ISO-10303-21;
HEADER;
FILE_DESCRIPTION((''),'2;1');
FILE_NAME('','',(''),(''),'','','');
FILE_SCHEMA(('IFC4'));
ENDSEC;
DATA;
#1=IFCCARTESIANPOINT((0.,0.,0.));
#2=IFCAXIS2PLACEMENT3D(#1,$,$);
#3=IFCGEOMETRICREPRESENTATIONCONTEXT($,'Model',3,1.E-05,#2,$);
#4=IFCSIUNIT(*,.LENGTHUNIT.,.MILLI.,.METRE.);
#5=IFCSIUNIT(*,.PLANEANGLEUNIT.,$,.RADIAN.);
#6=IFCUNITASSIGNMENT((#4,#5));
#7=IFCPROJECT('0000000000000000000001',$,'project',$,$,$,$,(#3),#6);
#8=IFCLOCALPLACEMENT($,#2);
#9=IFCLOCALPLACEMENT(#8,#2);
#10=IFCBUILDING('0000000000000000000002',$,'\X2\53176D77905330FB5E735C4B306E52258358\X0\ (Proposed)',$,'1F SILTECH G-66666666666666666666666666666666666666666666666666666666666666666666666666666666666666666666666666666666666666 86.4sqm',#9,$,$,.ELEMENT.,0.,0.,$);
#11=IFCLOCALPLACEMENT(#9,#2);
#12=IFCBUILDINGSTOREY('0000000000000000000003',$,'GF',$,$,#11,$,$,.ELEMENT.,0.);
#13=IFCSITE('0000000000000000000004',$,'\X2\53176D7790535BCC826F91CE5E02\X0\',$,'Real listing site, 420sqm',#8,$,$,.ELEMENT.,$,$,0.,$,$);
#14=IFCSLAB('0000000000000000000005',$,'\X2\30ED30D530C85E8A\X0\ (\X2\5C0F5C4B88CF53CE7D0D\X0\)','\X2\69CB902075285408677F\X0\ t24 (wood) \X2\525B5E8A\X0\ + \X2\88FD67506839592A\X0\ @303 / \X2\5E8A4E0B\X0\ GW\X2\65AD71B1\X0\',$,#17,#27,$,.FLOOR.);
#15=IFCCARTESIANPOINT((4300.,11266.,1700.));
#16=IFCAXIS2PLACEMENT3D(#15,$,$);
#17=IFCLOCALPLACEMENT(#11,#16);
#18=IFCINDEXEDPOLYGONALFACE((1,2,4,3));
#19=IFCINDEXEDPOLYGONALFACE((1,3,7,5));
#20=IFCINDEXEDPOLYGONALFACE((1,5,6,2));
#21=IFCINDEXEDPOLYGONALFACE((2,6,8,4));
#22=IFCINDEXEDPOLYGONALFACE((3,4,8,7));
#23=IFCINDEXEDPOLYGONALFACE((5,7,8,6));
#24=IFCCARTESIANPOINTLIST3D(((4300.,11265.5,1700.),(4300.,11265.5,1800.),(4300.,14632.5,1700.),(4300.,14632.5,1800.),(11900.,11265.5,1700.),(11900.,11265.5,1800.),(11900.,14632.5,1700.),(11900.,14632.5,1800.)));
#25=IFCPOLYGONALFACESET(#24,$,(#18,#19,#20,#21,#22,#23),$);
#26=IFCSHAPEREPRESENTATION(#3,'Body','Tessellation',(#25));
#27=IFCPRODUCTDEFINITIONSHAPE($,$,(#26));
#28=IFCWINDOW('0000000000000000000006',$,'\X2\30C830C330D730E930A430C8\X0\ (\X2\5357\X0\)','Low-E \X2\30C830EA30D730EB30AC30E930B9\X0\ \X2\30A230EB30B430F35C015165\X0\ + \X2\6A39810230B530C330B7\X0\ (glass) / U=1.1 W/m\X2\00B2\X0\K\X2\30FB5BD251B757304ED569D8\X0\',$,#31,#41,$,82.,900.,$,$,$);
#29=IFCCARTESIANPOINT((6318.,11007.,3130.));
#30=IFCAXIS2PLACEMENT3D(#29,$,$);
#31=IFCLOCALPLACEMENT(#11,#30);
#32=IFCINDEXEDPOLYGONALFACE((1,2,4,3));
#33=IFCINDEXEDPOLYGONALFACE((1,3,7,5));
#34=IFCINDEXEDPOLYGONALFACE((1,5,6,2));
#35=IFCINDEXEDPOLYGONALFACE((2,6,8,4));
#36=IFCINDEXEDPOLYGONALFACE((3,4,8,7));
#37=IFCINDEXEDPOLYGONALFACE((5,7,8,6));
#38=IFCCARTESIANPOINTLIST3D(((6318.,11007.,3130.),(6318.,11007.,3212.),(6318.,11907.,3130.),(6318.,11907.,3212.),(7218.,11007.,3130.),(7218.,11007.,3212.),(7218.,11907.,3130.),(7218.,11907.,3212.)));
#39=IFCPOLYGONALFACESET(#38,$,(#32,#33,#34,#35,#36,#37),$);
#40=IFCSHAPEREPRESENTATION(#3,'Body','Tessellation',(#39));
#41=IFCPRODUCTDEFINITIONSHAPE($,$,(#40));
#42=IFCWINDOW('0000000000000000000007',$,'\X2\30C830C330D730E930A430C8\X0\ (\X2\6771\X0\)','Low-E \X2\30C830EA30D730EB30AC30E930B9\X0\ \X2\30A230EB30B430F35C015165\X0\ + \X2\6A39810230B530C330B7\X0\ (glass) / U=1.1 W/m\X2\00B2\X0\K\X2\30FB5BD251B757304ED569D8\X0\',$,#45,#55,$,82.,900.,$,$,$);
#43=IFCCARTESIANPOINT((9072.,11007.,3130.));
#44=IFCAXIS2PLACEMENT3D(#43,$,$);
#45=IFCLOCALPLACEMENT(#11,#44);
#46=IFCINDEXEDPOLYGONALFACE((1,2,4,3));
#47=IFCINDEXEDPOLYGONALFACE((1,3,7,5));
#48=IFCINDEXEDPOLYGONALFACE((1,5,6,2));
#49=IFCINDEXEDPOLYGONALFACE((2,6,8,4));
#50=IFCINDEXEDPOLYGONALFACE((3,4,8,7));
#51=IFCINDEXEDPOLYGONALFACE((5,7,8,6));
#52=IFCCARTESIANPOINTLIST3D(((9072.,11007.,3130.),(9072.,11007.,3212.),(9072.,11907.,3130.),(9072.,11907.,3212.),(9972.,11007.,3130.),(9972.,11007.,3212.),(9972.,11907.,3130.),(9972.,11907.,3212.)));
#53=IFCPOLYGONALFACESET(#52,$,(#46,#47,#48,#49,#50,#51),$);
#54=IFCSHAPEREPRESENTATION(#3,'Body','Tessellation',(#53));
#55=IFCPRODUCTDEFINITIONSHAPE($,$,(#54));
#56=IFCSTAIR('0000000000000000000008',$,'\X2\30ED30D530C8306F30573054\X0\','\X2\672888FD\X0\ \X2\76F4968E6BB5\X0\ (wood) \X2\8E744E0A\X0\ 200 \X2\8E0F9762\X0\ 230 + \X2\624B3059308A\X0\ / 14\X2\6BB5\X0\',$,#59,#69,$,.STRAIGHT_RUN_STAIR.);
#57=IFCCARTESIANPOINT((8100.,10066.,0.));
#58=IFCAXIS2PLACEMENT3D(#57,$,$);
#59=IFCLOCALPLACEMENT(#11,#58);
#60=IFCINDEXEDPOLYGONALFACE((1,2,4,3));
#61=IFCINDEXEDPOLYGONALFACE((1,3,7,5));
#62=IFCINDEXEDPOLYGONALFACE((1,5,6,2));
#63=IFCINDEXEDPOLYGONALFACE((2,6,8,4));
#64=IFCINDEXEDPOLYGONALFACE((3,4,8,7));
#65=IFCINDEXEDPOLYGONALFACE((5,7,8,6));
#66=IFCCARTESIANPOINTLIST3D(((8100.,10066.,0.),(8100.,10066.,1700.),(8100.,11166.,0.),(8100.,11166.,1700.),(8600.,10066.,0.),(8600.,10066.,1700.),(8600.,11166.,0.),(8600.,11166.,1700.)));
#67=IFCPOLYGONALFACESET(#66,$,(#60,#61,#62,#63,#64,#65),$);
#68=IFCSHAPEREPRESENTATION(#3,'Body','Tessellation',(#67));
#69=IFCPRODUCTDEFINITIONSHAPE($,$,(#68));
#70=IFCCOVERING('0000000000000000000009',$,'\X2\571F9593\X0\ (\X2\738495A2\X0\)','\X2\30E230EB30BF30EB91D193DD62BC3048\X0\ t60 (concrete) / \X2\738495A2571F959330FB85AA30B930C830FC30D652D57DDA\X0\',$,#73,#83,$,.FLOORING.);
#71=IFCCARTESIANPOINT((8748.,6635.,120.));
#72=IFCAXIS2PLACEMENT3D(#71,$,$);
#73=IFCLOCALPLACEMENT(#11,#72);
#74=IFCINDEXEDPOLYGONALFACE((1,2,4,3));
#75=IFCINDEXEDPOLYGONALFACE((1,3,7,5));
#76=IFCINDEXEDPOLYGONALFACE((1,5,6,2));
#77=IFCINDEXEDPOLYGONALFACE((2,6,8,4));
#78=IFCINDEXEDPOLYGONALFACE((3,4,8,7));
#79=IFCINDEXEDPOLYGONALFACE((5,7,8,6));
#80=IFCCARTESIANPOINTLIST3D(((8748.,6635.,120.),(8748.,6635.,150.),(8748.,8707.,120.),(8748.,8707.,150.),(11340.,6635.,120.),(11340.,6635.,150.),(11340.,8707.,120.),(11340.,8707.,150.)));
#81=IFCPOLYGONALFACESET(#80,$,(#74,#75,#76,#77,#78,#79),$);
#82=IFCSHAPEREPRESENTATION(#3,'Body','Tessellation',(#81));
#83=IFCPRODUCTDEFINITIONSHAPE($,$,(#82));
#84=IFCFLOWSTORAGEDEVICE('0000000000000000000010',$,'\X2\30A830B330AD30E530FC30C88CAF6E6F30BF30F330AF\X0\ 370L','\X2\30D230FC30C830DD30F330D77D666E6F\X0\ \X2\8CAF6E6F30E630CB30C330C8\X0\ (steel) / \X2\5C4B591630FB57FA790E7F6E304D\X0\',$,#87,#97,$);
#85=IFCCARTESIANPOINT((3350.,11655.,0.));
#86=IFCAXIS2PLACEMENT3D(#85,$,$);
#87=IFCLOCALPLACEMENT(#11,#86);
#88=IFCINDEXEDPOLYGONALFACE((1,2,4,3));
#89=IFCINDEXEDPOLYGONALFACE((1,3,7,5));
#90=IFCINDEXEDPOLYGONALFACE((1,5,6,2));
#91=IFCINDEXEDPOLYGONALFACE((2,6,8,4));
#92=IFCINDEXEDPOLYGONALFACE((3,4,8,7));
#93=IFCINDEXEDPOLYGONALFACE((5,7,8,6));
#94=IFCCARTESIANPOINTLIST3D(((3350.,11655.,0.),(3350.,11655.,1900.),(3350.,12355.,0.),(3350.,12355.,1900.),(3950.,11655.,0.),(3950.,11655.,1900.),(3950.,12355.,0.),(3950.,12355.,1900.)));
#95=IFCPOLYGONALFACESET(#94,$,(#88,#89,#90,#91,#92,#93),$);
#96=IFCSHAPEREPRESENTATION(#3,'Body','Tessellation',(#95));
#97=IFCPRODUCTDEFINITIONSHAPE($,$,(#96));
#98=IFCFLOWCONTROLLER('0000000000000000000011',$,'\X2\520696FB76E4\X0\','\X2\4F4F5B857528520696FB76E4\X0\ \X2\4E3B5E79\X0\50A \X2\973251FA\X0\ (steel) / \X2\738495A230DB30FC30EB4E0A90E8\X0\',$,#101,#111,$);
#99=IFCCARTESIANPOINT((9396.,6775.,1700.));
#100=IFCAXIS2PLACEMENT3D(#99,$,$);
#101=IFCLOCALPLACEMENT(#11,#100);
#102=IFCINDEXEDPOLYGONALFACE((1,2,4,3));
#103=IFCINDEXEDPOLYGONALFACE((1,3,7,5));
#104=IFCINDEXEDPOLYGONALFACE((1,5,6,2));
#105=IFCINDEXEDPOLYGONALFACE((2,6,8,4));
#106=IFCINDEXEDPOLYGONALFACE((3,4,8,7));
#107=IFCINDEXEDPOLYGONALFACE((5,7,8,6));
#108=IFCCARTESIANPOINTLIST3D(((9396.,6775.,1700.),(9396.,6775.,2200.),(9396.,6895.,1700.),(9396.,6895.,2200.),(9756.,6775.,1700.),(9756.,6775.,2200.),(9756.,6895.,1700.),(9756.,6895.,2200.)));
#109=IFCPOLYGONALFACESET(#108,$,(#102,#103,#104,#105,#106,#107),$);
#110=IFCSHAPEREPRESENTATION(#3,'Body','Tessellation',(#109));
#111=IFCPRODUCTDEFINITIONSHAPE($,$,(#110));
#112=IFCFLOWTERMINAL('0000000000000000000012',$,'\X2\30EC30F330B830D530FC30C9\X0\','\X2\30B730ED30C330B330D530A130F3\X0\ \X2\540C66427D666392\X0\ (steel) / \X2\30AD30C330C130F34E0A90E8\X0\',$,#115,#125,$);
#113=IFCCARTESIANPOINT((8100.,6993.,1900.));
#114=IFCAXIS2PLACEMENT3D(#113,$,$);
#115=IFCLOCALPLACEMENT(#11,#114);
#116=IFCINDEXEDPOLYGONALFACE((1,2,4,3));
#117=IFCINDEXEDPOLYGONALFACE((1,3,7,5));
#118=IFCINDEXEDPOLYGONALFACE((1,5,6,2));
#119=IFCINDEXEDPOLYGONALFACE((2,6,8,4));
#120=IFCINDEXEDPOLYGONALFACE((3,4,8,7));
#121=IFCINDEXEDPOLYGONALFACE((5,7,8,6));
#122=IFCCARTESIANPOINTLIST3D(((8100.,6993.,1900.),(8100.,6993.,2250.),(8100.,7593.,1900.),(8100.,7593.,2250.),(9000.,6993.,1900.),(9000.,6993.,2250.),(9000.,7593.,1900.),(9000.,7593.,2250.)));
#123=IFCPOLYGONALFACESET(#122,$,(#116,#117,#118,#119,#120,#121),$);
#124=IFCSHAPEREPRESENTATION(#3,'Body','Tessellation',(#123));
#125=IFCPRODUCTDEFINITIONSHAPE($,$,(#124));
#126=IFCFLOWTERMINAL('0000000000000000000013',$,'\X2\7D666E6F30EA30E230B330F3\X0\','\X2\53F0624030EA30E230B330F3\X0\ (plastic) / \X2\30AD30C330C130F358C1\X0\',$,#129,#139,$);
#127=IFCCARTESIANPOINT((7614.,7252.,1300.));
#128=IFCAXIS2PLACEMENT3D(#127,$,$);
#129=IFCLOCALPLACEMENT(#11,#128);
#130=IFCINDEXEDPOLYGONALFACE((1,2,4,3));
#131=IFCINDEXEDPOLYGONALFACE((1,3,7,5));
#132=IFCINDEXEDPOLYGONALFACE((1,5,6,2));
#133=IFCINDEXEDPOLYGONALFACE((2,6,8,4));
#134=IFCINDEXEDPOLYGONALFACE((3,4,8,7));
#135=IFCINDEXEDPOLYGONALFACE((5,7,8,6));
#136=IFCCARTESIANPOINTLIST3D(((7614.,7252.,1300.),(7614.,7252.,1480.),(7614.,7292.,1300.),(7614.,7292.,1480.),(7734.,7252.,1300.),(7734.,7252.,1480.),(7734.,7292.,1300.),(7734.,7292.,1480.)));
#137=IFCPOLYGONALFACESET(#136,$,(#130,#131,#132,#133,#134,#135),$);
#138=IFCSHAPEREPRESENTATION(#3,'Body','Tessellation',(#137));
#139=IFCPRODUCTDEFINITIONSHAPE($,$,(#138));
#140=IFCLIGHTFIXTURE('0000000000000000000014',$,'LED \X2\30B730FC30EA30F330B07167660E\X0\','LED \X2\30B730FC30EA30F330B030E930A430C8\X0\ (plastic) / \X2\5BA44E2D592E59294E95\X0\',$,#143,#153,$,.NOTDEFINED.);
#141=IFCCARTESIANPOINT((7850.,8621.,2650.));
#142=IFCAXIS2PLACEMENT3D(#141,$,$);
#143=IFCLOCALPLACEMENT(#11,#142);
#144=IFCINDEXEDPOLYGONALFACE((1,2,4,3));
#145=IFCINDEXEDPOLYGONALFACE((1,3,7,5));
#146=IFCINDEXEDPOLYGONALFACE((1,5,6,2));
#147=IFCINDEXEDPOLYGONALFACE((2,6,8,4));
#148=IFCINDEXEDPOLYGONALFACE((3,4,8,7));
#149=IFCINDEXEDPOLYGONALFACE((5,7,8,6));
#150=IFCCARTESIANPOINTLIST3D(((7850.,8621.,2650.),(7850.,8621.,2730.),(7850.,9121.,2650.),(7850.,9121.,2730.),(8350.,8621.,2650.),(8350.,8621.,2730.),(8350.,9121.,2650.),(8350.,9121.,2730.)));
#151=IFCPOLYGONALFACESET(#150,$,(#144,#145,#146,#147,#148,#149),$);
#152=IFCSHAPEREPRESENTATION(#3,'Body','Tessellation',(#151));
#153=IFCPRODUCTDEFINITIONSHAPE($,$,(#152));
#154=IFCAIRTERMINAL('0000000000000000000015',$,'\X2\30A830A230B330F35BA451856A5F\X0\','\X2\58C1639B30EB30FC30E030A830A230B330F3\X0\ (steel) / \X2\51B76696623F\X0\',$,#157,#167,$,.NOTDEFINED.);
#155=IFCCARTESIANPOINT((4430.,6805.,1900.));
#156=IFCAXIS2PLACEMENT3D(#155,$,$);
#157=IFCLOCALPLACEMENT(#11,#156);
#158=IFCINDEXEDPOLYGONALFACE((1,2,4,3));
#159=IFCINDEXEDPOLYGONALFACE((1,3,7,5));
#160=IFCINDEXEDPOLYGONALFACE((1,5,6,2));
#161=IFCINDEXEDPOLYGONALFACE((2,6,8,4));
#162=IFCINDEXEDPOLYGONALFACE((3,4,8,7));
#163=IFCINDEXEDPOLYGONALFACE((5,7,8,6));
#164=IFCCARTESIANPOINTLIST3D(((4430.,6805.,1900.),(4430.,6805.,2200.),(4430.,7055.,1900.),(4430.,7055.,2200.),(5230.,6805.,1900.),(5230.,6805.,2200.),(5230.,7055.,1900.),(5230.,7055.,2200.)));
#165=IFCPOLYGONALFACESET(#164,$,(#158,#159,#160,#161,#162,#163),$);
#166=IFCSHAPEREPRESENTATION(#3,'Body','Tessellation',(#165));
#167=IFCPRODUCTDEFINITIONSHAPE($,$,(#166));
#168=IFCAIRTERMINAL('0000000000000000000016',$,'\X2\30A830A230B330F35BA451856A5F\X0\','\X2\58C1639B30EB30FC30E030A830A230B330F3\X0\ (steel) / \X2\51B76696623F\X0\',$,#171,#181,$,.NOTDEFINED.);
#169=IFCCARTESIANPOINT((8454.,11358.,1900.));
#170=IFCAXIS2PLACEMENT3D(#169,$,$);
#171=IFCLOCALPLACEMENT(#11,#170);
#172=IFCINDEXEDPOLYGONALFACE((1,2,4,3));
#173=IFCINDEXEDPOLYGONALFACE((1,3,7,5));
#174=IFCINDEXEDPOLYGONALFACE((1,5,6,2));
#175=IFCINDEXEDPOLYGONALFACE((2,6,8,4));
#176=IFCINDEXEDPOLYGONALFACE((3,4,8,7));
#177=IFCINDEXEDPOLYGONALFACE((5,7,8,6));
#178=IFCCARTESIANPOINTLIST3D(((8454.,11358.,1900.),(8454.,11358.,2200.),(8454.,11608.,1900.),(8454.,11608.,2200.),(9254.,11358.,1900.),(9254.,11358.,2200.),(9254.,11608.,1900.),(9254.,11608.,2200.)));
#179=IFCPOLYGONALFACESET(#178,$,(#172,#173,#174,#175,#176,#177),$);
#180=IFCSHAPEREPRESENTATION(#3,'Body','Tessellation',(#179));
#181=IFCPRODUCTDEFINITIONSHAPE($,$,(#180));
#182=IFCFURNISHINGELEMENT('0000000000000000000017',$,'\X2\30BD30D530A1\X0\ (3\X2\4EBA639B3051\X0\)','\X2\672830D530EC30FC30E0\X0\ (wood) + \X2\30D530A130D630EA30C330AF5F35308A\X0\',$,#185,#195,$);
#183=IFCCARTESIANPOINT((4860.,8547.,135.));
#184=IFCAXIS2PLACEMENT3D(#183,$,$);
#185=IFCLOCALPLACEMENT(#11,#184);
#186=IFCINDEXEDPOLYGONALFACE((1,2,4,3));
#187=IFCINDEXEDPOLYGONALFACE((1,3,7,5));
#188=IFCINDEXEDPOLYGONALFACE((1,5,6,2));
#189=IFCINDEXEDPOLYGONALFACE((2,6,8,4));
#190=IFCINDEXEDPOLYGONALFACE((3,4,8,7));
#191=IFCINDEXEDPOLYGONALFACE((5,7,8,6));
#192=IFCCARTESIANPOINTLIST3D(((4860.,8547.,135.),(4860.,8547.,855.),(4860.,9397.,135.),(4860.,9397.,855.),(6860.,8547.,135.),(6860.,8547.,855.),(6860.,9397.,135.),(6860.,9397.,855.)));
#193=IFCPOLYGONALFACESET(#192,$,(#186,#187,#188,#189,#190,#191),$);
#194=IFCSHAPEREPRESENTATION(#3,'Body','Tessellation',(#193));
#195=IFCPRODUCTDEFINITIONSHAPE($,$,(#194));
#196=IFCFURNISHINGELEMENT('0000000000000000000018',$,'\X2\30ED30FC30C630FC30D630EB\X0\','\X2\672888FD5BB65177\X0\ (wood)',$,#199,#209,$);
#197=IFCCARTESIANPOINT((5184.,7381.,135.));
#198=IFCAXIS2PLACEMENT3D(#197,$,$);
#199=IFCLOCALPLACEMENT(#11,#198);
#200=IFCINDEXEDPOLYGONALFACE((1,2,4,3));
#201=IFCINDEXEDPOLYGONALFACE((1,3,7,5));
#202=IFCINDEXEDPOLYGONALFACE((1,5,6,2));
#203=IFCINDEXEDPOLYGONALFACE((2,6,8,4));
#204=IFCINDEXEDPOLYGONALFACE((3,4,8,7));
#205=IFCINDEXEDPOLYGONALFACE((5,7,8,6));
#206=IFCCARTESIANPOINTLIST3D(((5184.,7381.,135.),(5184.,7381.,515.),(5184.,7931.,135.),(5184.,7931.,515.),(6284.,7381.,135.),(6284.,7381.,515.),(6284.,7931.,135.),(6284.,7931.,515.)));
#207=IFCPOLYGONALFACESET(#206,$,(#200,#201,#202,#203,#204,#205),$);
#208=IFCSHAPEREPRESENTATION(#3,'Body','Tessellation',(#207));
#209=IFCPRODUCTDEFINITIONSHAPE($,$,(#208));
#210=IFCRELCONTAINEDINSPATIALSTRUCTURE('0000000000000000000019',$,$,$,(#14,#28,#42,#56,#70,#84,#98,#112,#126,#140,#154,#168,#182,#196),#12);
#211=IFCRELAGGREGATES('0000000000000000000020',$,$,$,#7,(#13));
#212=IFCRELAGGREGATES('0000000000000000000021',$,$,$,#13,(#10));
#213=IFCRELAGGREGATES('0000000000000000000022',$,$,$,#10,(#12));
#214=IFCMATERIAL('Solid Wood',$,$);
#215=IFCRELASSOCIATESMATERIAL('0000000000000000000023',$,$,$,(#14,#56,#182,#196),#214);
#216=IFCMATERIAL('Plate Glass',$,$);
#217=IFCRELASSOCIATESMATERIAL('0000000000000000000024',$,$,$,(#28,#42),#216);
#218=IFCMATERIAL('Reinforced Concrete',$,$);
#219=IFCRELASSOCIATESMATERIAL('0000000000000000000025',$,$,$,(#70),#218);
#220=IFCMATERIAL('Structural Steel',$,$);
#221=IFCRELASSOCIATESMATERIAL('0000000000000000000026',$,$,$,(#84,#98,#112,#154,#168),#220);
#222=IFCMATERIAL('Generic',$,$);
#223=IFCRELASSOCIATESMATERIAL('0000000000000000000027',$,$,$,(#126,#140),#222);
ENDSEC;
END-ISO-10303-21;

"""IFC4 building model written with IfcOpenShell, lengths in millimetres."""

from ifc_helpers import new_model, si_unit, frame, frame_2d, origin, place, context, project, spatial, rectangle, extrude, material, element, save


model = new_model("IFC4")

# Units and contexts
model_context = context("Model", 3, precision=1e-05, world=origin())
ifc_project = project(units=[si_unit("LENGTHUNIT", "METRE", prefix="MILLI"), si_unit("PLANEANGLEUNIT", "RADIAN")], contexts=[model_context])

# Site, building, storey
site_placement = place(None, origin())
site = spatial("IfcSite", under=ifc_project, at=site_placement, Name="北海道富良野市", ObjectType="Real listing site, 420sqm", CompositionType="ELEMENT", RefElevation=0.0)
building_placement = place(site_placement, origin())
building = spatial("IfcBuilding", under=site, at=building_placement, Name="北海道・平屋の別荘 (Proposed)", ObjectType="1F SILTECH G-66666666666666666666666666666666666666666666666666666666666666666666666666666666666666666666666666666666666666 86.4sqm", CompositionType="ELEMENT", ElevationOfRefHeight=0.0, ElevationOfTerrain=0.0)
storey_placement = place(building_placement, origin())
storey = spatial("IfcBuildingStorey", under=building, at=storey_placement, Name="GF", CompositionType="ELEMENT", Elevation=0.0)

# Shared definitions
ifc_material_1 = material(Name="Solid Wood")

# Slab
slab_placement = place(storey_placement, frame((4300.0, 11266.0, 1700.0)))
element("IfcSlab", 1, at=slab_placement, inside=storey, material=ifc_material_1, Name="ロフト床 (小屋裏収納)", Description="構造用合板 t24 (wood) 剛床 + 製材根太 @303 / 床下 GW断熱", PredefinedType="FLOOR", context=model_context, shape_type="SweptSolid", body=[
    extrude(rectangle(XDim=7600.0, YDim=3367.0, at=frame_2d((3800.0, 1683.0))), frame((4300.0, 11266.0, 1700.0)), (0.0, 0.0, 1.0), 100.0),
])

# Windows
ifc_material_2 = material(Name="Plate Glass")
window_1_placement = place(storey_placement, frame((6318.0, 11007.0, 3130.0)))
element("IfcWindow", 2, at=window_1_placement, inside=storey, material=ifc_material_2, Name="トップライト (南)", Description="Low-E トリプルガラス アルゴン封入 + 樹脂サッシ (glass) / U=1.1 W/m²K・寒冷地仕様", OverallHeight=82.0, OverallWidth=900.0, context=model_context, shape_type="SweptSolid", body=[
    extrude(rectangle(XDim=900.0, YDim=900.0, at=frame_2d((450.0, 450.0))), frame((6318.0, 11007.0, 3130.0)), (0.0, 0.0, 1.0), 82.0),
])
window_2_placement = place(storey_placement, frame((9072.0, 11007.0, 3130.0)))
element("IfcWindow", 3, at=window_2_placement, inside=storey, material=ifc_material_2, Name="トップライト (東)", Description="Low-E トリプルガラス アルゴン封入 + 樹脂サッシ (glass) / U=1.1 W/m²K・寒冷地仕様", OverallHeight=82.0, OverallWidth=900.0, context=model_context, shape_type="SweptSolid", body=[
    extrude(rectangle(XDim=900.0, YDim=900.0, at=frame_2d((450.0, 450.0))), frame((9072.0, 11007.0, 3130.0)), (0.0, 0.0, 1.0), 82.0),
])

# Stair
stair_placement = place(storey_placement, frame((8100.0, 10066.0, 0.0)))
element("IfcStair", 4, at=stair_placement, inside=storey, material=ifc_material_1, Name="ロフトはしご", Description="木製 直階段 (wood) 蹴上 200 踏面 230 + 手すり / 14段", PredefinedType="STRAIGHT_RUN_STAIR", context=model_context, shape_type="SweptSolid", body=[
    extrude(rectangle(XDim=500.0, YDim=1100.0, at=frame_2d((250.0, 550.0))), frame((8100.0, 10066.0, 0.0)), (0.0, 0.0, 1.0), 1700.0),
])

# Covering
ifc_material_3 = material(Name="Reinforced Concrete")
covering_placement = place(storey_placement, frame((8748.0, 6635.0, 120.0)))
element("IfcCovering", 5, at=covering_placement, inside=storey, material=ifc_material_3, Name="土間 (玄関)", Description="モルタル金鏝押え t60 (concrete) / 玄関土間・薪ストーブ動線", PredefinedType="FLOORING", context=model_context, shape_type="SweptSolid", body=[
    extrude(rectangle(XDim=2592.0, YDim=2072.0, at=frame_2d((1296.0, 1036.0))), frame((8748.0, 6635.0, 120.0)), (0.0, 0.0, 1.0), 30.0),
])

# Flow storage device
ifc_material_4 = material(Name="Structural Steel")
flow_storage_device_placement = place(storey_placement, frame((3350.0, 11655.0, 0.0)))
element("IfcFlowStorageDevice", 6, at=flow_storage_device_placement, inside=storey, material=ifc_material_4, Name="エコキュート貯湯タンク 370L", Description="ヒートポンプ給湯 貯湯ユニット (steel) / 屋外・基礎置き", context=model_context, shape_type="SweptSolid", body=[
    extrude(rectangle(XDim=600.0, YDim=700.0, at=frame_2d((300.0, 350.0))), frame((3350.0, 11655.0, 0.0)), (0.0, 0.0, 1.0), 1900.0),
])

# Flow controller
flow_controller_placement = place(storey_placement, frame((9396.0, 6775.0, 1700.0)))
element("IfcFlowController", 7, at=flow_controller_placement, inside=storey, material=ifc_material_4, Name="分電盤", Description="住宅用分電盤 主幹50A 露出 (steel) / 玄関ホール上部", context=model_context, shape_type="SweptSolid", body=[
    extrude(rectangle(XDim=360.0, YDim=120.0, at=frame_2d((180.0, 60.0))), frame((9396.0, 6775.0, 1700.0)), (0.0, 0.0, 1.0), 500.0),
])

# Flow terminals
flow_terminal_1_placement = place(storey_placement, frame((8100.0, 6993.0, 1900.0)))
element("IfcFlowTerminal", 8, at=flow_terminal_1_placement, inside=storey, material=ifc_material_4, Name="レンジフード", Description="シロッコファン 同時給排 (steel) / キッチン上部", context=model_context, shape_type="SweptSolid", body=[
    extrude(rectangle(XDim=900.0, YDim=600.0, at=frame_2d((450.0, 300.0))), frame((8100.0, 6993.0, 1900.0)), (0.0, 0.0, 1.0), 350.0),
])
ifc_material_5 = material(Name="Generic")
flow_terminal_2_placement = place(storey_placement, frame((7614.0, 7252.0, 1300.0)))
element("IfcFlowTerminal", 9, at=flow_terminal_2_placement, inside=storey, material=ifc_material_5, Name="給湯リモコン", Description="台所リモコン (plastic) / キッチン壁", context=model_context, shape_type="SweptSolid", body=[
    extrude(rectangle(XDim=120.0, YDim=40.0, at=frame_2d((60.0, 20.0))), frame((7614.0, 7252.0, 1300.0)), (0.0, 0.0, 1.0), 180.0),
])

# Light fixture
light_fixture_placement = place(storey_placement, frame((7850.0, 8621.0, 2650.0)))
element("IfcLightFixture", 10, at=light_fixture_placement, inside=storey, material=ifc_material_5, Name="LED シーリング照明", Description="LED シーリングライト (plastic) / 室中央天井", PredefinedType="NOTDEFINED", context=model_context, shape_type="SweptSolid", body=[
    extrude(rectangle(XDim=500.0, YDim=500.0, at=frame_2d((250.0, 250.0))), frame((7850.0, 8621.0, 2650.0)), (0.0, 0.0, 1.0), 80.0),
])

# Air terminals
air_terminal_1_placement = place(storey_placement, frame((4430.0, 6805.0, 1900.0)))
element("IfcAirTerminal", 11, at=air_terminal_1_placement, inside=storey, material=ifc_material_4, Name="エアコン室内機", Description="壁掛ルームエアコン (steel) / 冷暖房", PredefinedType="NOTDEFINED", context=model_context, shape_type="SweptSolid", body=[
    extrude(rectangle(XDim=800.0, YDim=250.0, at=frame_2d((400.0, 125.0))), frame((4430.0, 6805.0, 1900.0)), (0.0, 0.0, 1.0), 300.0),
])
air_terminal_2_placement = place(storey_placement, frame((8454.0, 11358.0, 1900.0)))
element("IfcAirTerminal", 12, at=air_terminal_2_placement, inside=storey, material=ifc_material_4, Name="エアコン室内機", Description="壁掛ルームエアコン (steel) / 冷暖房", PredefinedType="NOTDEFINED", context=model_context, shape_type="SweptSolid", body=[
    extrude(rectangle(XDim=800.0, YDim=250.0, at=frame_2d((400.0, 125.0))), frame((8454.0, 11358.0, 1900.0)), (0.0, 0.0, 1.0), 300.0),
])

# Furnishing elements
furnishing_1_placement = place(storey_placement, frame((4860.0, 8547.0, 135.0)))
element("IfcFurnishingElement", 13, at=furnishing_1_placement, inside=storey, material=ifc_material_1, Name="ソファ (3人掛け)", Description="木フレーム (wood) + ファブリック張り", context=model_context, shape_type="SweptSolid", body=[
    extrude(rectangle(XDim=2000.0, YDim=850.0, at=frame_2d((1000.0, 425.0))), frame((4860.0, 8547.0, 135.0)), (0.0, 0.0, 1.0), 720.0),
])
furnishing_2_placement = place(storey_placement, frame((5184.0, 7381.0, 135.0)))
element("IfcFurnishingElement", 14, at=furnishing_2_placement, inside=storey, material=ifc_material_1, Name="ローテーブル", Description="木製家具 (wood)", context=model_context, shape_type="SweptSolid", body=[
    extrude(rectangle(XDim=1100.0, YDim=550.0, at=frame_2d((550.0, 275.0))), frame((5184.0, 7381.0, 135.0)), (0.0, 0.0, 1.0), 380.0),
])

save(model, "model.ifc")
